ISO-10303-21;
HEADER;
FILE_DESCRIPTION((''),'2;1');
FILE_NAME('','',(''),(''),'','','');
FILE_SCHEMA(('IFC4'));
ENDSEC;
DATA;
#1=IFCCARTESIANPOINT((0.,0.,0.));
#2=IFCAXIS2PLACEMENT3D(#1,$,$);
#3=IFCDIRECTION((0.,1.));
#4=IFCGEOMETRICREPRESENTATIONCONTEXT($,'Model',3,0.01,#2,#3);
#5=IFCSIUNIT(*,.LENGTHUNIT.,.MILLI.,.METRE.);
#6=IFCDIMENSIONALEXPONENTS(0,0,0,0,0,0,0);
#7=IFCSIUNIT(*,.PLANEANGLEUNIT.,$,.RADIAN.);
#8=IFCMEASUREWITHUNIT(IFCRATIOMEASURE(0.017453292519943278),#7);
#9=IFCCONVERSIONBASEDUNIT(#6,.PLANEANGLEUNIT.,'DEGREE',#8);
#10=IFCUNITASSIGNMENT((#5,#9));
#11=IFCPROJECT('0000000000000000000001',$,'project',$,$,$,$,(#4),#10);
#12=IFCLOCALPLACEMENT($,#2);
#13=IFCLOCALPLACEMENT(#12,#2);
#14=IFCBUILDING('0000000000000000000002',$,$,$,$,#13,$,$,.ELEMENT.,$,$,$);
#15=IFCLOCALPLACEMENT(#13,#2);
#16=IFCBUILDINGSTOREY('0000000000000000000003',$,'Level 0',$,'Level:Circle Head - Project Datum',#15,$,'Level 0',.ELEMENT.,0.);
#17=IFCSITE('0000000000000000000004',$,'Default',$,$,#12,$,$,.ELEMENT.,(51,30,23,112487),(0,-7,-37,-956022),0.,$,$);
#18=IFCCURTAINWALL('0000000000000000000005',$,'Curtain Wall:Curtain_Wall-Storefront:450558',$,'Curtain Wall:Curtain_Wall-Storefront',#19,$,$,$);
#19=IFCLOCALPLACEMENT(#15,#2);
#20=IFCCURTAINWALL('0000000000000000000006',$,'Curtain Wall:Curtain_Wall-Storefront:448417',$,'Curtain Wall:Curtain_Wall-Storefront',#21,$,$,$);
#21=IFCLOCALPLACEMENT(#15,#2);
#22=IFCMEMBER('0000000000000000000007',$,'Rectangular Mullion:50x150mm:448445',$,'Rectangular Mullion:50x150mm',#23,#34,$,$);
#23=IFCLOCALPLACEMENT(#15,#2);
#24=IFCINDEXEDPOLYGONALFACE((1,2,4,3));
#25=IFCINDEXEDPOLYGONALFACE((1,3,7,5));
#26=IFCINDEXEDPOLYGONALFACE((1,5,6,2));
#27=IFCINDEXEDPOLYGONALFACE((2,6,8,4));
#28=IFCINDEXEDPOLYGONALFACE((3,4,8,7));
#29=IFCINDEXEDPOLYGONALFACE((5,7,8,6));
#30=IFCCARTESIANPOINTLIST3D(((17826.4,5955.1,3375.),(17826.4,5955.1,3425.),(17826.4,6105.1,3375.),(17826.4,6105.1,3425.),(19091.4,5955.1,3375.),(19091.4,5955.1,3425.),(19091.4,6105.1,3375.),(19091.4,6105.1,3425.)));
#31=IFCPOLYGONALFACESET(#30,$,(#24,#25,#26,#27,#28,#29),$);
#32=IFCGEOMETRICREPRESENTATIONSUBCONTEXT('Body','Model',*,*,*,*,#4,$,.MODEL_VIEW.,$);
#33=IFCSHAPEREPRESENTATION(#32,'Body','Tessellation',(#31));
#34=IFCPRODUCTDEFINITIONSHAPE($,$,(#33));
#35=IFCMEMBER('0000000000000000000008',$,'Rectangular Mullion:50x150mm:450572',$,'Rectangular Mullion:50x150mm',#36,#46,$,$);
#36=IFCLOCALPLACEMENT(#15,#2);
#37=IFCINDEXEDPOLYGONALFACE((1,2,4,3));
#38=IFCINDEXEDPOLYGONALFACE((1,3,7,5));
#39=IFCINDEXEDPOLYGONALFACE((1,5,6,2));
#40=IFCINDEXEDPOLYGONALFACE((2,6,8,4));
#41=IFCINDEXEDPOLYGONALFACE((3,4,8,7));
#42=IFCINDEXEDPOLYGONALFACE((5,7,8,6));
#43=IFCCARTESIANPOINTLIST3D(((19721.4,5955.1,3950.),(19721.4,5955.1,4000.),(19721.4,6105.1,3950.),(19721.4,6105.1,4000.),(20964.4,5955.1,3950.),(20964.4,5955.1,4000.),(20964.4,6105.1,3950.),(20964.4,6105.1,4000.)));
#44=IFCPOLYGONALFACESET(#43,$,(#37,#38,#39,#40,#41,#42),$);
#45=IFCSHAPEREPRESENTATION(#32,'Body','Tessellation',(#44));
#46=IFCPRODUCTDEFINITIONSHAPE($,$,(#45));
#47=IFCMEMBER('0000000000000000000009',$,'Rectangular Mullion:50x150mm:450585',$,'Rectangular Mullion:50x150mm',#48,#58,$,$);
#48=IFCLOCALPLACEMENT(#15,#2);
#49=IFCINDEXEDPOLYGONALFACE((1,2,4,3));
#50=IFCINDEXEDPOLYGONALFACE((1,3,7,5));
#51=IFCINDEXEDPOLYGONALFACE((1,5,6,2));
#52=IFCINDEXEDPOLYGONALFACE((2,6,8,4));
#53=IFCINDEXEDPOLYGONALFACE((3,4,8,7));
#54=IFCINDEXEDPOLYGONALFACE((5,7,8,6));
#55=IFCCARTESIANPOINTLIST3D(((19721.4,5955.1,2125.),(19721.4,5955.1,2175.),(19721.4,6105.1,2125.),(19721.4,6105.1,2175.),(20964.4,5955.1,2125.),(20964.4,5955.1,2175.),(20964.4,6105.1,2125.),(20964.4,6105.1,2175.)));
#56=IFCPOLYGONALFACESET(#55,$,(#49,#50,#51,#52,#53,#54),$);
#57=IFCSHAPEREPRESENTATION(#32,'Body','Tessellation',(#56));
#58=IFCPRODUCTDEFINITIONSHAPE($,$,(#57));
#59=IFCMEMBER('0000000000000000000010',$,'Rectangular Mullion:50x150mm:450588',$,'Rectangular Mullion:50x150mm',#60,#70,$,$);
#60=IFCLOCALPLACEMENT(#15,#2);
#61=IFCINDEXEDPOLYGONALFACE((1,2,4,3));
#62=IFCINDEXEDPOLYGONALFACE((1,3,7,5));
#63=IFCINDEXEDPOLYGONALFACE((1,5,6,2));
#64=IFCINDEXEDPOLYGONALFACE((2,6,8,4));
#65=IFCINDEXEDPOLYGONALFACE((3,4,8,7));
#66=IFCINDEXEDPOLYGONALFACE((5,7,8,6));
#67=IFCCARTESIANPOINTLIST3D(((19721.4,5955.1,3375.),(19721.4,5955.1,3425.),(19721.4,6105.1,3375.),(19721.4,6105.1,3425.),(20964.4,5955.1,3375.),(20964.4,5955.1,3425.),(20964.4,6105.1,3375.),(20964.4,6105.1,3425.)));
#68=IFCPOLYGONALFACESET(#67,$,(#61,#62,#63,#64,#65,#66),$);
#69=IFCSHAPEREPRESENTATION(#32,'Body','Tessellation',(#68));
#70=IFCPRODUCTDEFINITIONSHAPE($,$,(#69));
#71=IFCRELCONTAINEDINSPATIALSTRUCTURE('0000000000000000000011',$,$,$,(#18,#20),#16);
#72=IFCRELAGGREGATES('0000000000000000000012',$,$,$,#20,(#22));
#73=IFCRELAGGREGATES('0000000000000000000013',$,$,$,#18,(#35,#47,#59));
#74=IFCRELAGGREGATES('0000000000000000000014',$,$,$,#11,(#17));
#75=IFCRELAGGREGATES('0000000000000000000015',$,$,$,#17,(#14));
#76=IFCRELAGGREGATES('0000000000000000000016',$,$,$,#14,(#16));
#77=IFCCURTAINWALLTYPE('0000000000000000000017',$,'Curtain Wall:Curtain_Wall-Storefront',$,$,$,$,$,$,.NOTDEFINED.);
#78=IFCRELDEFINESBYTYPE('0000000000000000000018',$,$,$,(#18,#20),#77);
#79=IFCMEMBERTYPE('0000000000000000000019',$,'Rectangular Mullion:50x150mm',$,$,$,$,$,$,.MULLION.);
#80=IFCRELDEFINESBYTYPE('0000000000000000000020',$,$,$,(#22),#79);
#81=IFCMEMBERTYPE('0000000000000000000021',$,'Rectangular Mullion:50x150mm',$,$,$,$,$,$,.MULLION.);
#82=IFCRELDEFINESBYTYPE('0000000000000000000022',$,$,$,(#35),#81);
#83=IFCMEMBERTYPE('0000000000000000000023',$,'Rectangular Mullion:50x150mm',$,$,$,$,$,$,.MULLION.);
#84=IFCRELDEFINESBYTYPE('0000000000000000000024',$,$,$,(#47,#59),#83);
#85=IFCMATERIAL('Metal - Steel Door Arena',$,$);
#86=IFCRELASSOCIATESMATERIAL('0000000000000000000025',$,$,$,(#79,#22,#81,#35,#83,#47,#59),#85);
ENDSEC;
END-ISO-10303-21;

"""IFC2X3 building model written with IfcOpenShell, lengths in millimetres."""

from ifc_helpers import new_model, entity, si_unit, converted_unit, direction, frame, origin, origin_2d_with_axis, place, context, subcontext, project, spatial, rectangle, extrude, source, transform, mapped, material, type_object, type_shapes, element, aggregate, save


model = new_model("IFC2X3")

# Units and contexts
model_context = context("Model", 3, precision=0.01, world=origin(), true_north=direction((0.0, 1.0)))
body_context = subcontext(model_context, "Body", "Model", "MODEL_VIEW")
ifc_project = project(units=[si_unit("LENGTHUNIT", "METRE", prefix="MILLI"), converted_unit("PLANEANGLEUNIT", "DEGREE", entity("IfcRatioMeasure", 0.017453292519943278), si_unit("PLANEANGLEUNIT", "RADIAN"), dimensions=[0, 0, 0, 0, 0, 0, 0])], contexts=[model_context])

# Site, building, storey
site_placement = place(None, origin())
site = spatial("IfcSite", under=ifc_project, at=site_placement, Name="Default", CompositionType="ELEMENT", RefLatitude=(51, 30, 23, 112487), RefLongitude=(0, -7, -37, -956022), RefElevation=0.0)
building_placement = place(site_placement, origin())
building = spatial("IfcBuilding", under=site, at=building_placement, CompositionType="ELEMENT")
storey_placement = place(building_placement, origin())
storey = spatial("IfcBuildingStorey", under=building, at=storey_placement, Name="Level 0", ObjectType="Level:Circle Head - Project Datum", LongName="Level 0", CompositionType="ELEMENT", Elevation=0.0)

# Curtain walls, member
curtain_wall_type = type_object("IfcCurtainWallType", Name="Curtain Wall:Curtain_Wall-Storefront", PredefinedType="NOTDEFINED")
curtain_wall_1_placement = place(storey_placement, origin())
curtain_wall_1 = element("IfcCurtainWall", 1, at=curtain_wall_1_placement, inside=storey, type_object=curtain_wall_type, Name="Curtain Wall:Curtain_Wall-Storefront:450558", ObjectType="Curtain Wall:Curtain_Wall-Storefront")
ifc_material_1 = material(Name="Metal - Steel Door Arena")
curtain_wall_2_placement = place(storey_placement, origin())
curtain_wall_2 = element("IfcCurtainWall", 2, at=curtain_wall_2_placement, inside=storey, type_object=curtain_wall_type, Name="Curtain Wall:Curtain_Wall-Storefront:448417", ObjectType="Curtain Wall:Curtain_Wall-Storefront")
member_type_1 = type_object("IfcMemberType", Name="Rectangular Mullion:50x150mm", PredefinedType="MULLION", material=ifc_material_1)
shared_shape_1 = source(origin(), body_context, "Body", "SweptSolid", [
    extrude(rectangle(XDim=150.0, YDim=50.0, at=origin_2d_with_axis()), frame((0.0, 0.0, -1265.0), z_axis=(0.0, 0.0, 1.0), x_axis=(0.0, -1.0, 0.0)), (0.0, 0.0, 1.0), 1265.0),
])
type_shapes(member_type_1, [shared_shape_1])
member_1_placement = place(curtain_wall_2_placement, frame((17826.4, 6030.1, 3400.0), z_axis=(-1.0, 0.0, 0.0), x_axis=(0.0, 0.0, 1.0)))
member_1 = element("IfcMember", 3, at=member_1_placement, type_object=member_type_1, material=ifc_material_1, Name="Rectangular Mullion:50x150mm:448445", ObjectType="Rectangular Mullion:50x150mm", context=body_context, shape_type="MappedRepresentation", body=[
    mapped(shared_shape_1, transform((0.0, 0.0, 0.0), scale=1.0)),
])

# Members
member_type_2 = type_object("IfcMemberType", Name="Rectangular Mullion:50x150mm", PredefinedType="MULLION", material=ifc_material_1)
shared_shape_2 = source(origin(), body_context, "Body", "SweptSolid", [
    extrude(rectangle(XDim=150.0, YDim=50.0, at=origin_2d_with_axis()), frame((-25.0, 0.0, -1243.0), z_axis=(0.0, 0.0, 1.0), x_axis=(0.0, -1.0, 0.0)), (0.0, 0.0, 1.0), 1243.0),
])
type_shapes(member_type_2, [shared_shape_2])
member_2_placement = place(curtain_wall_1_placement, frame((19721.4, 6030.1, 4000.0), z_axis=(-1.0, 0.0, 0.0), x_axis=(0.0, 0.0, 1.0)))
member_2 = element("IfcMember", 4, at=member_2_placement, type_object=member_type_2, material=ifc_material_1, Name="Rectangular Mullion:50x150mm:450572", ObjectType="Rectangular Mullion:50x150mm", context=body_context, shape_type="MappedRepresentation", body=[
    mapped(shared_shape_2, transform((0.0, 0.0, 0.0), scale=1.0)),
])
member_type_3 = type_object("IfcMemberType", Name="Rectangular Mullion:50x150mm", PredefinedType="MULLION", material=ifc_material_1)
shared_shape_3 = source(origin(), body_context, "Body", "SweptSolid", [
    extrude(rectangle(XDim=150.0, YDim=50.0, at=origin_2d_with_axis()), frame((0.0, 0.0, -1243.0), z_axis=(0.0, 0.0, 1.0), x_axis=(0.0, -1.0, 0.0)), (0.0, 0.0, 1.0), 1243.0),
])
type_shapes(member_type_3, [shared_shape_3])
member_3_placement = place(curtain_wall_1_placement, frame((19721.4, 6030.1, 2150.0), z_axis=(-1.0, 0.0, 0.0), x_axis=(0.0, 0.0, 1.0)))
member_3 = element("IfcMember", 5, at=member_3_placement, type_object=member_type_3, material=ifc_material_1, Name="Rectangular Mullion:50x150mm:450585", ObjectType="Rectangular Mullion:50x150mm", context=body_context, shape_type="MappedRepresentation", body=[
    mapped(shared_shape_3, transform((0.0, 0.0, 0.0), scale=1.0)),
])
member_4_placement = place(curtain_wall_1_placement, frame((19721.4, 6030.1, 3400.0), z_axis=(-1.0, 0.0, 0.0), x_axis=(0.0, 0.0, 1.0)))
member_4 = element("IfcMember", 6, at=member_4_placement, type_object=member_type_3, material=ifc_material_1, Name="Rectangular Mullion:50x150mm:450588", ObjectType="Rectangular Mullion:50x150mm", context=body_context, shape_type="MappedRepresentation", body=[
    mapped(shared_shape_3, transform((0.0, 0.0, 0.0), scale=1.0)),
])

aggregate(curtain_wall_2, [member_1])
aggregate(curtain_wall_1, [member_2, member_3, member_4])

save(model, "model.ifc")
